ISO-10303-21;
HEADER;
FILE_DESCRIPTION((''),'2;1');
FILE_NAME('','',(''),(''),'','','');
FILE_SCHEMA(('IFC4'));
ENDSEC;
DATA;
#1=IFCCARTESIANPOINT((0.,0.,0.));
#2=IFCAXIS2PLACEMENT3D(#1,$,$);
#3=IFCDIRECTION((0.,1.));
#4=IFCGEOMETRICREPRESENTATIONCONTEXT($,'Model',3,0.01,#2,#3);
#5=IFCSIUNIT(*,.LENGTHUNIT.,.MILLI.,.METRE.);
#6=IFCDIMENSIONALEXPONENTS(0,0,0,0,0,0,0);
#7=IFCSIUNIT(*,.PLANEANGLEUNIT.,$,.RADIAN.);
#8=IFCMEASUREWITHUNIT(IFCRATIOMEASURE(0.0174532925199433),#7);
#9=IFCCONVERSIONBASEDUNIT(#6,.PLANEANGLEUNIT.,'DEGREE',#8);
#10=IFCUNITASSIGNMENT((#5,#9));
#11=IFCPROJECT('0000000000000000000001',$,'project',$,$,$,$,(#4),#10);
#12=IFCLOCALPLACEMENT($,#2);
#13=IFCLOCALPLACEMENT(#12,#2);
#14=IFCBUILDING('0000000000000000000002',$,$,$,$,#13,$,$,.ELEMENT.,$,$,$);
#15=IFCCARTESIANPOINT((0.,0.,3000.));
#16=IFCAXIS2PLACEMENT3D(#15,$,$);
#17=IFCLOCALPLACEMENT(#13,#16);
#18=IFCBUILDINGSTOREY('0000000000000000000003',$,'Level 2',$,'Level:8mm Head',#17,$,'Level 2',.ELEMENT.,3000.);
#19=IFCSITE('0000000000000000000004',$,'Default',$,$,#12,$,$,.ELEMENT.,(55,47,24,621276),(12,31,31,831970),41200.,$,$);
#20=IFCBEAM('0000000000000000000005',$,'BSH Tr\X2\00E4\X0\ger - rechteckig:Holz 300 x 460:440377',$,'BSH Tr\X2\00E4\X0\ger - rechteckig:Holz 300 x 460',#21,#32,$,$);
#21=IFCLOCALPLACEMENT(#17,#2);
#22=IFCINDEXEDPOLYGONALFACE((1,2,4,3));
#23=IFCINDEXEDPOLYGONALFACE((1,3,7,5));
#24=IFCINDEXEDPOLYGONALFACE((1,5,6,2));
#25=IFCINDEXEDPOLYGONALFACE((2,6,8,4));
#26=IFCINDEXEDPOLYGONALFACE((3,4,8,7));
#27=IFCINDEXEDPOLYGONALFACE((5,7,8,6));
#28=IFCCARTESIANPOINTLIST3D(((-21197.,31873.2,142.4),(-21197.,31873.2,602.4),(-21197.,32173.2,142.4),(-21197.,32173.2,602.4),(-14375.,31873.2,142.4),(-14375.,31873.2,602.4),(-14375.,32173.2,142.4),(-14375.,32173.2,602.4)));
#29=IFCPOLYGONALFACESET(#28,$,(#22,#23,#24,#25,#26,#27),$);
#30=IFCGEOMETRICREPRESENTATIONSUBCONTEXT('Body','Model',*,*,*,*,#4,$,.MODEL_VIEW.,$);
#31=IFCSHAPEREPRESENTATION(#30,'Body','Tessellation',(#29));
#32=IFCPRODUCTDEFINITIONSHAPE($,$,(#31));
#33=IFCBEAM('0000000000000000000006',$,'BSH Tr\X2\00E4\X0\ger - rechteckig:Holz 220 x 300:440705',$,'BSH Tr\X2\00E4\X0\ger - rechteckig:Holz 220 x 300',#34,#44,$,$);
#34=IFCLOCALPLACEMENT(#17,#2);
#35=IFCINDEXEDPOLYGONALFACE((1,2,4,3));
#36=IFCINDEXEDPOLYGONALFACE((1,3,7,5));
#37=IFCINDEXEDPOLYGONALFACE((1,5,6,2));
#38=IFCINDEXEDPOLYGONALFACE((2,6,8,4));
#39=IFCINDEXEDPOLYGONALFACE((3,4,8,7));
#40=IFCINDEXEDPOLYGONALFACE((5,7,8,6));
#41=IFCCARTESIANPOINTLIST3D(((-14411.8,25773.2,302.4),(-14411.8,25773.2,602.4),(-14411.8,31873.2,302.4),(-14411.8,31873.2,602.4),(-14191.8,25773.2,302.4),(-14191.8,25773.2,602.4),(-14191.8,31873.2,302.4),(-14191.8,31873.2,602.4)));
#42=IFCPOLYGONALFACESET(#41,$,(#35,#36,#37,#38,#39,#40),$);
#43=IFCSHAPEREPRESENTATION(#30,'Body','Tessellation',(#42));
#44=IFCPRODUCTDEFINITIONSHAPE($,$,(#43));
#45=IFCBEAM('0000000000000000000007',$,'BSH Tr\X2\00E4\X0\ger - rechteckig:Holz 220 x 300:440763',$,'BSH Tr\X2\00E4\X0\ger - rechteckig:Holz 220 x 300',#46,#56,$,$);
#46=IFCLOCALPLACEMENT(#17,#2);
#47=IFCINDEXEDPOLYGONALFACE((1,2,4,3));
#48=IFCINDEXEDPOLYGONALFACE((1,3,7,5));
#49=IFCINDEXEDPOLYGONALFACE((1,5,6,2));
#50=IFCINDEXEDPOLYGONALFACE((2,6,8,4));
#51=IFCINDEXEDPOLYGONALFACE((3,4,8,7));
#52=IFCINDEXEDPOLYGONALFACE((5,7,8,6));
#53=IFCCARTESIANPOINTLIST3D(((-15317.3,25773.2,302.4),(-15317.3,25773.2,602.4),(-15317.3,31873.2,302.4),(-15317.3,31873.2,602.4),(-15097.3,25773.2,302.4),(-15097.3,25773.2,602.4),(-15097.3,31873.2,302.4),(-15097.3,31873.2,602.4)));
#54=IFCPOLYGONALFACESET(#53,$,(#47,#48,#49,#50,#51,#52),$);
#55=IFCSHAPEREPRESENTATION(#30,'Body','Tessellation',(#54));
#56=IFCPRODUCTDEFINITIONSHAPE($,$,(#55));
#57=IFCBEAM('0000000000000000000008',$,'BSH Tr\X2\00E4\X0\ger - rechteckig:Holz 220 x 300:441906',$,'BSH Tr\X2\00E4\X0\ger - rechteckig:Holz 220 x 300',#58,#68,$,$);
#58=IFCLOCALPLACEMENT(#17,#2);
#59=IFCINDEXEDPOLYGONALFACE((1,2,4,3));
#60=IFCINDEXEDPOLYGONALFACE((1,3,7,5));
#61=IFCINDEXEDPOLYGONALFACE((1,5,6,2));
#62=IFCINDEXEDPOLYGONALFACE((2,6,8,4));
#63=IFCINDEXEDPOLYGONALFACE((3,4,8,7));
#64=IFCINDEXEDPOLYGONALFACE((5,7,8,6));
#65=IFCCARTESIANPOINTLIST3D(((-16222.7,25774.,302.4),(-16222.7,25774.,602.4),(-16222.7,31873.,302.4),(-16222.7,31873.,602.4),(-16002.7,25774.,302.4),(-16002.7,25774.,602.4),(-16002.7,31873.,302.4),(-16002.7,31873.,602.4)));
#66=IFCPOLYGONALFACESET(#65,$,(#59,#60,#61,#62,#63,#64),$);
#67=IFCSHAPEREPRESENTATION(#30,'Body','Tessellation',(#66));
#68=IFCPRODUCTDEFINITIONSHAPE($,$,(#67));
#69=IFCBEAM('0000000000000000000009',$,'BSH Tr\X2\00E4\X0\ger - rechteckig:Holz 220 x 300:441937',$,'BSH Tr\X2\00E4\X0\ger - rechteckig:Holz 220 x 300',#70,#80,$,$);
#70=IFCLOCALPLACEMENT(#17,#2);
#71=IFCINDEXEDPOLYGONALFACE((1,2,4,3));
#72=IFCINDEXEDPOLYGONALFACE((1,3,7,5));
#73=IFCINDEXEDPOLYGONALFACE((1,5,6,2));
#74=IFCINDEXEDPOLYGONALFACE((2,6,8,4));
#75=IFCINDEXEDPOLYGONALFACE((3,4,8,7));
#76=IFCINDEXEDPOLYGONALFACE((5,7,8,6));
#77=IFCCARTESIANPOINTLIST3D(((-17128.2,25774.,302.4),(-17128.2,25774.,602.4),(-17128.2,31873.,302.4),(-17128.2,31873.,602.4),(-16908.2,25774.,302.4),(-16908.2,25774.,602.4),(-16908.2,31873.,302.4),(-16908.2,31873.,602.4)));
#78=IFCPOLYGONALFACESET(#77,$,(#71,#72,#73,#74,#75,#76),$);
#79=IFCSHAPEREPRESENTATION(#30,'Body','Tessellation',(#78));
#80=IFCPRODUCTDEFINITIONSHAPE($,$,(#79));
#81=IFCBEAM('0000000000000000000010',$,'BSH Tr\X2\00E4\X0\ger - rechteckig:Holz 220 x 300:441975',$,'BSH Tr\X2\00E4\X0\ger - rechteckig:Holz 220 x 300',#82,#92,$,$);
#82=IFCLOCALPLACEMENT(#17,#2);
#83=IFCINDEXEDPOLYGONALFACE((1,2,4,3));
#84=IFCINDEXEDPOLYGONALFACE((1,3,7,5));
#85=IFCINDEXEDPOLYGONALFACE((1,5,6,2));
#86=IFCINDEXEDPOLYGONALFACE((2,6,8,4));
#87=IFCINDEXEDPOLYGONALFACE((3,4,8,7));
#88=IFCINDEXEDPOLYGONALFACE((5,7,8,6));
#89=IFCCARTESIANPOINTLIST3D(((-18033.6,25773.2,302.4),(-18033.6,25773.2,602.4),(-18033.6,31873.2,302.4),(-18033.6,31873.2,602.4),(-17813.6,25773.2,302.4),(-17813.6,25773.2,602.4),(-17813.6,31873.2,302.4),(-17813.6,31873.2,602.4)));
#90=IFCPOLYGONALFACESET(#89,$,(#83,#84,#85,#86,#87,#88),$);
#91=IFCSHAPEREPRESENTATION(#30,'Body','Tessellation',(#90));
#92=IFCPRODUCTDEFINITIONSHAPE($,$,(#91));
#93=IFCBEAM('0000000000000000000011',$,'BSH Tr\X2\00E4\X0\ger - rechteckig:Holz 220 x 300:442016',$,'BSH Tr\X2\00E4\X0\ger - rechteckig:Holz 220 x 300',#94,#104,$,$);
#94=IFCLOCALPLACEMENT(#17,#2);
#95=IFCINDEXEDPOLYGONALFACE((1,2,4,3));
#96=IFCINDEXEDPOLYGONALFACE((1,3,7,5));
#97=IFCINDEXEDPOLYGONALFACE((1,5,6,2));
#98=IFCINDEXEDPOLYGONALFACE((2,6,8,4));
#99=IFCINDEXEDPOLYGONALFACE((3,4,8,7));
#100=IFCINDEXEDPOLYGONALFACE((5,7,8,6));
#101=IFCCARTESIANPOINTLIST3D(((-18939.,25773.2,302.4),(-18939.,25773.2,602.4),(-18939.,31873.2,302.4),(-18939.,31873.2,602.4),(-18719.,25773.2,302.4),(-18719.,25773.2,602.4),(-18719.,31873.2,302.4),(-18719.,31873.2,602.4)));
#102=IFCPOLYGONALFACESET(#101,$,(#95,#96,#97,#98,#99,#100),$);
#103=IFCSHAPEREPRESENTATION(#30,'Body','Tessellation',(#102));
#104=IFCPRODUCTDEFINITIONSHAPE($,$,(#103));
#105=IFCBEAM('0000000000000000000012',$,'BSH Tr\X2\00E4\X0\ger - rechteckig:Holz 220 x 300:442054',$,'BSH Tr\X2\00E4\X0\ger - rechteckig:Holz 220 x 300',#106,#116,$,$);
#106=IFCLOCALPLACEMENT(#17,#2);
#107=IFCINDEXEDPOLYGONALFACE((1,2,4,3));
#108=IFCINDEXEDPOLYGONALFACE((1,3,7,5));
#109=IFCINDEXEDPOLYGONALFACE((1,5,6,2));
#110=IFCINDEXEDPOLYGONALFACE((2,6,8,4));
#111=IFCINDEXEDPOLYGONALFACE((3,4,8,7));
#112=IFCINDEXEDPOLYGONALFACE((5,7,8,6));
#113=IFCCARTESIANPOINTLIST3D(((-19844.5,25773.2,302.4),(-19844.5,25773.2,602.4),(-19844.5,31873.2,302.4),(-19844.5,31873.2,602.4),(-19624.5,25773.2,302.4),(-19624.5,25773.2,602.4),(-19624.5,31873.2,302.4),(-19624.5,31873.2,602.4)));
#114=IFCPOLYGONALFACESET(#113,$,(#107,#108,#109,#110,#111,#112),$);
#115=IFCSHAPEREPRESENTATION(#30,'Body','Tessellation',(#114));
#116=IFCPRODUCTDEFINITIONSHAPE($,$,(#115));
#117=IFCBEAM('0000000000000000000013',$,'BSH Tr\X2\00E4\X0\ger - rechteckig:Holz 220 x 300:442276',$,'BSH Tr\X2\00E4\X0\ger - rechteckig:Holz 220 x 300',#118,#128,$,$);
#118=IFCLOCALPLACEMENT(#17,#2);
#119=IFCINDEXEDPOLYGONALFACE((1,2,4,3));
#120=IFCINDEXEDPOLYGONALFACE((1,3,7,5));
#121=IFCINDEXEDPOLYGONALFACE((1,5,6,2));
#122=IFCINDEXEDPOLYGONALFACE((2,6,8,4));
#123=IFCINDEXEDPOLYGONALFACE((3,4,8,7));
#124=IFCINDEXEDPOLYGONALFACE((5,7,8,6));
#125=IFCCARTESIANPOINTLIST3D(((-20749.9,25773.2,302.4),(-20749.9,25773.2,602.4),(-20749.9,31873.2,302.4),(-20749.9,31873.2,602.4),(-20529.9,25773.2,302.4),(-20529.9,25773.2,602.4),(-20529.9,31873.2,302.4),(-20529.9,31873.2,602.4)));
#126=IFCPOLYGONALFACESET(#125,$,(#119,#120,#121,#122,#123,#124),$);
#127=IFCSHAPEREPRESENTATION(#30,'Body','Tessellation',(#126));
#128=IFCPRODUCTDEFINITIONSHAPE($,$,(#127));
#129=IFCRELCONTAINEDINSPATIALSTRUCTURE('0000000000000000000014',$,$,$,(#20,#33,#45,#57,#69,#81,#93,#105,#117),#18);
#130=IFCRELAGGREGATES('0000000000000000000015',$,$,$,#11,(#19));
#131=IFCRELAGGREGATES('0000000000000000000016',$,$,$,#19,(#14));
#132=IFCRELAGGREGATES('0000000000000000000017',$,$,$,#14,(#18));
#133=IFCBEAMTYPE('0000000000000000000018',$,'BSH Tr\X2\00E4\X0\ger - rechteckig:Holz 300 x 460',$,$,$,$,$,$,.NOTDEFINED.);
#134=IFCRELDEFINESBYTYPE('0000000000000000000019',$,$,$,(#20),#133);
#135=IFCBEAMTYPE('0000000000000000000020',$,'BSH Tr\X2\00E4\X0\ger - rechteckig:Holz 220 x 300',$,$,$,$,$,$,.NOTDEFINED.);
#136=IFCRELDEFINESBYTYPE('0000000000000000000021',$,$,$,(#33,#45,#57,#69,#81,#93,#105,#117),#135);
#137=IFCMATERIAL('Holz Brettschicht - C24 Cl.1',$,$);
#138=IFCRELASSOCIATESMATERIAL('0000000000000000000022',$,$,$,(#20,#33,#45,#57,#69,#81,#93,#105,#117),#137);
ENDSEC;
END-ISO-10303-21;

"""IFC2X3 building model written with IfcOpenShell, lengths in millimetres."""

from ifc_helpers import new_model, entity, si_unit, converted_unit, direction, frame, frame_2d, origin, origin_2d_with_axis, place, context, subcontext, project, spatial, rectangle, extrude, material, type_object, element, save


model = new_model("IFC2X3")

# Units and contexts
model_context = context("Model", 3, precision=0.01, world=origin(), true_north=direction((0.0, 1.0)))
body_context = subcontext(model_context, "Body", "Model", "MODEL_VIEW")
ifc_project = project(units=[si_unit("LENGTHUNIT", "METRE", prefix="MILLI"), converted_unit("PLANEANGLEUNIT", "DEGREE", entity("IfcRatioMeasure", 0.0174532925199433), si_unit("PLANEANGLEUNIT", "RADIAN"), dimensions=[0, 0, 0, 0, 0, 0, 0])], contexts=[model_context])

# Site, building, storey
site_placement = place(None, origin())
site = spatial("IfcSite", under=ifc_project, at=site_placement, Name="Default", CompositionType="ELEMENT", RefLatitude=(55, 47, 24, 621276), RefLongitude=(12, 31, 31, 831970), RefElevation=41200.0)
building_placement = place(site_placement, origin())
building = spatial("IfcBuilding", under=site, at=building_placement, CompositionType="ELEMENT")
storey_placement = place(building_placement, frame((0.0, 0.0, 3000.0)))
storey = spatial("IfcBuildingStorey", under=building, at=storey_placement, Name="Level 2", ObjectType="Level:8mm Head", LongName="Level 2", CompositionType="ELEMENT", Elevation=3000.0)

# Beams
ifc_material_1 = material(Name="Holz Brettschicht - C24 Cl.1")
beam_type_1 = type_object("IfcBeamType", Name="BSH Träger - rechteckig:Holz 300 x 460", PredefinedType="NOTDEFINED")
beam_1_placement = place(storey_placement, frame((-14041.8, 32023.2, 602.4), z_axis=(0.0, 0.0, 1.0), x_axis=(-1.0, 0.0, 0.0)))
element("IfcBeam", 1, at=beam_1_placement, inside=storey, type_object=beam_type_1, material=ifc_material_1, Name="BSH Träger - rechteckig:Holz 300 x 460:440377", ObjectType="BSH Träger - rechteckig:Holz 300 x 460", context=body_context, shape_type="SweptSolid", body=[
    extrude(rectangle(XDim=460.0, YDim=300.0, at=frame_2d((0.0, 0.0), x_axis=(1.0, 0.0))), frame((333.2, 0.0, -230.0), z_axis=(1.0, 0.0, 0.0), x_axis=(0.0, 0.0, -1.0)), (0.0, 0.0, 1.0), 6822.0),
])
beam_type_2 = type_object("IfcBeamType", Name="BSH Träger - rechteckig:Holz 220 x 300", PredefinedType="NOTDEFINED")
for number, where, z_axis, x_axis, name in (
    (2, (-14301.8, 32023.2, 602.4), (0.0, 0.0, 1.0), (0.0, -1.0, 0.0), "BSH Träger - rechteckig:Holz 220 x 300:440705"),
    (3, (-15207.3, 32023.2, 602.4), (0.0, 0.0, 1.0), (0.0, -1.0, 0.0), "BSH Träger - rechteckig:Holz 220 x 300:440763"),
):
    element("IfcBeam", number, at=place(storey_placement, frame(where, z_axis=z_axis, x_axis=x_axis)), inside=storey, type_object=beam_type_2, material=ifc_material_1, Name=name, ObjectType="BSH Träger - rechteckig:Holz 220 x 300", context=body_context, shape_type="SweptSolid", body=[
        extrude(rectangle(XDim=300.0, YDim=220.0, at=frame_2d((0.0, 0.0), x_axis=(1.0, 0.0))), frame((150.0, 0.0, -150.0), z_axis=(1.0, 0.0, 0.0), x_axis=(0.0, 0.0, -1.0)), (0.0, 0.0, 1.0), 6100.0),
    ])
for number, where, z_axis, x_axis, name in (
    (4, (-16112.7, 31936.0, 602.4), (0.0, 0.0, 1.0), (0.0, -1.0, 0.0), "BSH Träger - rechteckig:Holz 220 x 300:441906"),
    (5, (-17018.2, 31936.0, 602.4), (0.0, 0.0, 1.0), (0.0, -1.0, 0.0), "BSH Träger - rechteckig:Holz 220 x 300:441937"),
):
    element("IfcBeam", number, at=place(storey_placement, frame(where, z_axis=z_axis, x_axis=x_axis)), inside=storey, type_object=beam_type_2, material=ifc_material_1, Name=name, ObjectType="BSH Träger - rechteckig:Holz 220 x 300", context=body_context, shape_type="SweptSolid", body=[
        extrude(rectangle(XDim=300.0, YDim=220.0, at=frame_2d((0.0, 0.0), x_axis=(1.0, 0.0))), frame((63.0, 0.0, -150.0), z_axis=(1.0, 0.0, 0.0), x_axis=(0.0, 0.0, -1.0)), (0.0, 0.0, 1.0), 6099.0),
    ])
for number, where, z_axis, x_axis, name in (
    (6, (-17923.6, 32023.2, 602.4), (0.0, 0.0, 1.0), (0.0, -1.0, 0.0), "BSH Träger - rechteckig:Holz 220 x 300:441975"),
    (7, (-18829.0, 32023.2, 602.4), (0.0, 0.0, 1.0), (0.0, -1.0, 0.0), "BSH Träger - rechteckig:Holz 220 x 300:442016"),
):
    element("IfcBeam", number, at=place(storey_placement, frame(where, z_axis=z_axis, x_axis=x_axis)), inside=storey, type_object=beam_type_2, material=ifc_material_1, Name=name, ObjectType="BSH Träger - rechteckig:Holz 220 x 300", context=body_context, shape_type="SweptSolid", body=[
        extrude(rectangle(XDim=300.0, YDim=220.0, at=frame_2d((0.0, 0.0), x_axis=(1.0, 0.0))), frame((150.0, 0.0, -150.0), z_axis=(1.0, 0.0, 0.0), x_axis=(0.0, 0.0, -1.0)), (0.0, 0.0, 1.0), 6100.0),
    ])
for number, where, z_axis, x_axis, name in (
    (8, (-19734.5, 32023.2, 602.4), (0.0, 0.0, 1.0), (0.0, -1.0, 0.0), "BSH Träger - rechteckig:Holz 220 x 300:442054"),
    (9, (-20639.9, 32023.2, 602.4), (0.0, 0.0, 1.0), (0.0, -1.0, 0.0), "BSH Träger - rechteckig:Holz 220 x 300:442276"),
):
    element("IfcBeam", number, at=place(storey_placement, frame(where, z_axis=z_axis, x_axis=x_axis)), inside=storey, type_object=beam_type_2, material=ifc_material_1, Name=name, ObjectType="BSH Träger - rechteckig:Holz 220 x 300", context=body_context, shape_type="SweptSolid", body=[
        extrude(rectangle(XDim=300.0, YDim=220.0, at=origin_2d_with_axis()), frame((150.0, 0.0, -150.0), z_axis=(1.0, 0.0, 0.0), x_axis=(0.0, 0.0, -1.0)), (0.0, 0.0, 1.0), 6100.0),
    ])

save(model, "model.ifc")
